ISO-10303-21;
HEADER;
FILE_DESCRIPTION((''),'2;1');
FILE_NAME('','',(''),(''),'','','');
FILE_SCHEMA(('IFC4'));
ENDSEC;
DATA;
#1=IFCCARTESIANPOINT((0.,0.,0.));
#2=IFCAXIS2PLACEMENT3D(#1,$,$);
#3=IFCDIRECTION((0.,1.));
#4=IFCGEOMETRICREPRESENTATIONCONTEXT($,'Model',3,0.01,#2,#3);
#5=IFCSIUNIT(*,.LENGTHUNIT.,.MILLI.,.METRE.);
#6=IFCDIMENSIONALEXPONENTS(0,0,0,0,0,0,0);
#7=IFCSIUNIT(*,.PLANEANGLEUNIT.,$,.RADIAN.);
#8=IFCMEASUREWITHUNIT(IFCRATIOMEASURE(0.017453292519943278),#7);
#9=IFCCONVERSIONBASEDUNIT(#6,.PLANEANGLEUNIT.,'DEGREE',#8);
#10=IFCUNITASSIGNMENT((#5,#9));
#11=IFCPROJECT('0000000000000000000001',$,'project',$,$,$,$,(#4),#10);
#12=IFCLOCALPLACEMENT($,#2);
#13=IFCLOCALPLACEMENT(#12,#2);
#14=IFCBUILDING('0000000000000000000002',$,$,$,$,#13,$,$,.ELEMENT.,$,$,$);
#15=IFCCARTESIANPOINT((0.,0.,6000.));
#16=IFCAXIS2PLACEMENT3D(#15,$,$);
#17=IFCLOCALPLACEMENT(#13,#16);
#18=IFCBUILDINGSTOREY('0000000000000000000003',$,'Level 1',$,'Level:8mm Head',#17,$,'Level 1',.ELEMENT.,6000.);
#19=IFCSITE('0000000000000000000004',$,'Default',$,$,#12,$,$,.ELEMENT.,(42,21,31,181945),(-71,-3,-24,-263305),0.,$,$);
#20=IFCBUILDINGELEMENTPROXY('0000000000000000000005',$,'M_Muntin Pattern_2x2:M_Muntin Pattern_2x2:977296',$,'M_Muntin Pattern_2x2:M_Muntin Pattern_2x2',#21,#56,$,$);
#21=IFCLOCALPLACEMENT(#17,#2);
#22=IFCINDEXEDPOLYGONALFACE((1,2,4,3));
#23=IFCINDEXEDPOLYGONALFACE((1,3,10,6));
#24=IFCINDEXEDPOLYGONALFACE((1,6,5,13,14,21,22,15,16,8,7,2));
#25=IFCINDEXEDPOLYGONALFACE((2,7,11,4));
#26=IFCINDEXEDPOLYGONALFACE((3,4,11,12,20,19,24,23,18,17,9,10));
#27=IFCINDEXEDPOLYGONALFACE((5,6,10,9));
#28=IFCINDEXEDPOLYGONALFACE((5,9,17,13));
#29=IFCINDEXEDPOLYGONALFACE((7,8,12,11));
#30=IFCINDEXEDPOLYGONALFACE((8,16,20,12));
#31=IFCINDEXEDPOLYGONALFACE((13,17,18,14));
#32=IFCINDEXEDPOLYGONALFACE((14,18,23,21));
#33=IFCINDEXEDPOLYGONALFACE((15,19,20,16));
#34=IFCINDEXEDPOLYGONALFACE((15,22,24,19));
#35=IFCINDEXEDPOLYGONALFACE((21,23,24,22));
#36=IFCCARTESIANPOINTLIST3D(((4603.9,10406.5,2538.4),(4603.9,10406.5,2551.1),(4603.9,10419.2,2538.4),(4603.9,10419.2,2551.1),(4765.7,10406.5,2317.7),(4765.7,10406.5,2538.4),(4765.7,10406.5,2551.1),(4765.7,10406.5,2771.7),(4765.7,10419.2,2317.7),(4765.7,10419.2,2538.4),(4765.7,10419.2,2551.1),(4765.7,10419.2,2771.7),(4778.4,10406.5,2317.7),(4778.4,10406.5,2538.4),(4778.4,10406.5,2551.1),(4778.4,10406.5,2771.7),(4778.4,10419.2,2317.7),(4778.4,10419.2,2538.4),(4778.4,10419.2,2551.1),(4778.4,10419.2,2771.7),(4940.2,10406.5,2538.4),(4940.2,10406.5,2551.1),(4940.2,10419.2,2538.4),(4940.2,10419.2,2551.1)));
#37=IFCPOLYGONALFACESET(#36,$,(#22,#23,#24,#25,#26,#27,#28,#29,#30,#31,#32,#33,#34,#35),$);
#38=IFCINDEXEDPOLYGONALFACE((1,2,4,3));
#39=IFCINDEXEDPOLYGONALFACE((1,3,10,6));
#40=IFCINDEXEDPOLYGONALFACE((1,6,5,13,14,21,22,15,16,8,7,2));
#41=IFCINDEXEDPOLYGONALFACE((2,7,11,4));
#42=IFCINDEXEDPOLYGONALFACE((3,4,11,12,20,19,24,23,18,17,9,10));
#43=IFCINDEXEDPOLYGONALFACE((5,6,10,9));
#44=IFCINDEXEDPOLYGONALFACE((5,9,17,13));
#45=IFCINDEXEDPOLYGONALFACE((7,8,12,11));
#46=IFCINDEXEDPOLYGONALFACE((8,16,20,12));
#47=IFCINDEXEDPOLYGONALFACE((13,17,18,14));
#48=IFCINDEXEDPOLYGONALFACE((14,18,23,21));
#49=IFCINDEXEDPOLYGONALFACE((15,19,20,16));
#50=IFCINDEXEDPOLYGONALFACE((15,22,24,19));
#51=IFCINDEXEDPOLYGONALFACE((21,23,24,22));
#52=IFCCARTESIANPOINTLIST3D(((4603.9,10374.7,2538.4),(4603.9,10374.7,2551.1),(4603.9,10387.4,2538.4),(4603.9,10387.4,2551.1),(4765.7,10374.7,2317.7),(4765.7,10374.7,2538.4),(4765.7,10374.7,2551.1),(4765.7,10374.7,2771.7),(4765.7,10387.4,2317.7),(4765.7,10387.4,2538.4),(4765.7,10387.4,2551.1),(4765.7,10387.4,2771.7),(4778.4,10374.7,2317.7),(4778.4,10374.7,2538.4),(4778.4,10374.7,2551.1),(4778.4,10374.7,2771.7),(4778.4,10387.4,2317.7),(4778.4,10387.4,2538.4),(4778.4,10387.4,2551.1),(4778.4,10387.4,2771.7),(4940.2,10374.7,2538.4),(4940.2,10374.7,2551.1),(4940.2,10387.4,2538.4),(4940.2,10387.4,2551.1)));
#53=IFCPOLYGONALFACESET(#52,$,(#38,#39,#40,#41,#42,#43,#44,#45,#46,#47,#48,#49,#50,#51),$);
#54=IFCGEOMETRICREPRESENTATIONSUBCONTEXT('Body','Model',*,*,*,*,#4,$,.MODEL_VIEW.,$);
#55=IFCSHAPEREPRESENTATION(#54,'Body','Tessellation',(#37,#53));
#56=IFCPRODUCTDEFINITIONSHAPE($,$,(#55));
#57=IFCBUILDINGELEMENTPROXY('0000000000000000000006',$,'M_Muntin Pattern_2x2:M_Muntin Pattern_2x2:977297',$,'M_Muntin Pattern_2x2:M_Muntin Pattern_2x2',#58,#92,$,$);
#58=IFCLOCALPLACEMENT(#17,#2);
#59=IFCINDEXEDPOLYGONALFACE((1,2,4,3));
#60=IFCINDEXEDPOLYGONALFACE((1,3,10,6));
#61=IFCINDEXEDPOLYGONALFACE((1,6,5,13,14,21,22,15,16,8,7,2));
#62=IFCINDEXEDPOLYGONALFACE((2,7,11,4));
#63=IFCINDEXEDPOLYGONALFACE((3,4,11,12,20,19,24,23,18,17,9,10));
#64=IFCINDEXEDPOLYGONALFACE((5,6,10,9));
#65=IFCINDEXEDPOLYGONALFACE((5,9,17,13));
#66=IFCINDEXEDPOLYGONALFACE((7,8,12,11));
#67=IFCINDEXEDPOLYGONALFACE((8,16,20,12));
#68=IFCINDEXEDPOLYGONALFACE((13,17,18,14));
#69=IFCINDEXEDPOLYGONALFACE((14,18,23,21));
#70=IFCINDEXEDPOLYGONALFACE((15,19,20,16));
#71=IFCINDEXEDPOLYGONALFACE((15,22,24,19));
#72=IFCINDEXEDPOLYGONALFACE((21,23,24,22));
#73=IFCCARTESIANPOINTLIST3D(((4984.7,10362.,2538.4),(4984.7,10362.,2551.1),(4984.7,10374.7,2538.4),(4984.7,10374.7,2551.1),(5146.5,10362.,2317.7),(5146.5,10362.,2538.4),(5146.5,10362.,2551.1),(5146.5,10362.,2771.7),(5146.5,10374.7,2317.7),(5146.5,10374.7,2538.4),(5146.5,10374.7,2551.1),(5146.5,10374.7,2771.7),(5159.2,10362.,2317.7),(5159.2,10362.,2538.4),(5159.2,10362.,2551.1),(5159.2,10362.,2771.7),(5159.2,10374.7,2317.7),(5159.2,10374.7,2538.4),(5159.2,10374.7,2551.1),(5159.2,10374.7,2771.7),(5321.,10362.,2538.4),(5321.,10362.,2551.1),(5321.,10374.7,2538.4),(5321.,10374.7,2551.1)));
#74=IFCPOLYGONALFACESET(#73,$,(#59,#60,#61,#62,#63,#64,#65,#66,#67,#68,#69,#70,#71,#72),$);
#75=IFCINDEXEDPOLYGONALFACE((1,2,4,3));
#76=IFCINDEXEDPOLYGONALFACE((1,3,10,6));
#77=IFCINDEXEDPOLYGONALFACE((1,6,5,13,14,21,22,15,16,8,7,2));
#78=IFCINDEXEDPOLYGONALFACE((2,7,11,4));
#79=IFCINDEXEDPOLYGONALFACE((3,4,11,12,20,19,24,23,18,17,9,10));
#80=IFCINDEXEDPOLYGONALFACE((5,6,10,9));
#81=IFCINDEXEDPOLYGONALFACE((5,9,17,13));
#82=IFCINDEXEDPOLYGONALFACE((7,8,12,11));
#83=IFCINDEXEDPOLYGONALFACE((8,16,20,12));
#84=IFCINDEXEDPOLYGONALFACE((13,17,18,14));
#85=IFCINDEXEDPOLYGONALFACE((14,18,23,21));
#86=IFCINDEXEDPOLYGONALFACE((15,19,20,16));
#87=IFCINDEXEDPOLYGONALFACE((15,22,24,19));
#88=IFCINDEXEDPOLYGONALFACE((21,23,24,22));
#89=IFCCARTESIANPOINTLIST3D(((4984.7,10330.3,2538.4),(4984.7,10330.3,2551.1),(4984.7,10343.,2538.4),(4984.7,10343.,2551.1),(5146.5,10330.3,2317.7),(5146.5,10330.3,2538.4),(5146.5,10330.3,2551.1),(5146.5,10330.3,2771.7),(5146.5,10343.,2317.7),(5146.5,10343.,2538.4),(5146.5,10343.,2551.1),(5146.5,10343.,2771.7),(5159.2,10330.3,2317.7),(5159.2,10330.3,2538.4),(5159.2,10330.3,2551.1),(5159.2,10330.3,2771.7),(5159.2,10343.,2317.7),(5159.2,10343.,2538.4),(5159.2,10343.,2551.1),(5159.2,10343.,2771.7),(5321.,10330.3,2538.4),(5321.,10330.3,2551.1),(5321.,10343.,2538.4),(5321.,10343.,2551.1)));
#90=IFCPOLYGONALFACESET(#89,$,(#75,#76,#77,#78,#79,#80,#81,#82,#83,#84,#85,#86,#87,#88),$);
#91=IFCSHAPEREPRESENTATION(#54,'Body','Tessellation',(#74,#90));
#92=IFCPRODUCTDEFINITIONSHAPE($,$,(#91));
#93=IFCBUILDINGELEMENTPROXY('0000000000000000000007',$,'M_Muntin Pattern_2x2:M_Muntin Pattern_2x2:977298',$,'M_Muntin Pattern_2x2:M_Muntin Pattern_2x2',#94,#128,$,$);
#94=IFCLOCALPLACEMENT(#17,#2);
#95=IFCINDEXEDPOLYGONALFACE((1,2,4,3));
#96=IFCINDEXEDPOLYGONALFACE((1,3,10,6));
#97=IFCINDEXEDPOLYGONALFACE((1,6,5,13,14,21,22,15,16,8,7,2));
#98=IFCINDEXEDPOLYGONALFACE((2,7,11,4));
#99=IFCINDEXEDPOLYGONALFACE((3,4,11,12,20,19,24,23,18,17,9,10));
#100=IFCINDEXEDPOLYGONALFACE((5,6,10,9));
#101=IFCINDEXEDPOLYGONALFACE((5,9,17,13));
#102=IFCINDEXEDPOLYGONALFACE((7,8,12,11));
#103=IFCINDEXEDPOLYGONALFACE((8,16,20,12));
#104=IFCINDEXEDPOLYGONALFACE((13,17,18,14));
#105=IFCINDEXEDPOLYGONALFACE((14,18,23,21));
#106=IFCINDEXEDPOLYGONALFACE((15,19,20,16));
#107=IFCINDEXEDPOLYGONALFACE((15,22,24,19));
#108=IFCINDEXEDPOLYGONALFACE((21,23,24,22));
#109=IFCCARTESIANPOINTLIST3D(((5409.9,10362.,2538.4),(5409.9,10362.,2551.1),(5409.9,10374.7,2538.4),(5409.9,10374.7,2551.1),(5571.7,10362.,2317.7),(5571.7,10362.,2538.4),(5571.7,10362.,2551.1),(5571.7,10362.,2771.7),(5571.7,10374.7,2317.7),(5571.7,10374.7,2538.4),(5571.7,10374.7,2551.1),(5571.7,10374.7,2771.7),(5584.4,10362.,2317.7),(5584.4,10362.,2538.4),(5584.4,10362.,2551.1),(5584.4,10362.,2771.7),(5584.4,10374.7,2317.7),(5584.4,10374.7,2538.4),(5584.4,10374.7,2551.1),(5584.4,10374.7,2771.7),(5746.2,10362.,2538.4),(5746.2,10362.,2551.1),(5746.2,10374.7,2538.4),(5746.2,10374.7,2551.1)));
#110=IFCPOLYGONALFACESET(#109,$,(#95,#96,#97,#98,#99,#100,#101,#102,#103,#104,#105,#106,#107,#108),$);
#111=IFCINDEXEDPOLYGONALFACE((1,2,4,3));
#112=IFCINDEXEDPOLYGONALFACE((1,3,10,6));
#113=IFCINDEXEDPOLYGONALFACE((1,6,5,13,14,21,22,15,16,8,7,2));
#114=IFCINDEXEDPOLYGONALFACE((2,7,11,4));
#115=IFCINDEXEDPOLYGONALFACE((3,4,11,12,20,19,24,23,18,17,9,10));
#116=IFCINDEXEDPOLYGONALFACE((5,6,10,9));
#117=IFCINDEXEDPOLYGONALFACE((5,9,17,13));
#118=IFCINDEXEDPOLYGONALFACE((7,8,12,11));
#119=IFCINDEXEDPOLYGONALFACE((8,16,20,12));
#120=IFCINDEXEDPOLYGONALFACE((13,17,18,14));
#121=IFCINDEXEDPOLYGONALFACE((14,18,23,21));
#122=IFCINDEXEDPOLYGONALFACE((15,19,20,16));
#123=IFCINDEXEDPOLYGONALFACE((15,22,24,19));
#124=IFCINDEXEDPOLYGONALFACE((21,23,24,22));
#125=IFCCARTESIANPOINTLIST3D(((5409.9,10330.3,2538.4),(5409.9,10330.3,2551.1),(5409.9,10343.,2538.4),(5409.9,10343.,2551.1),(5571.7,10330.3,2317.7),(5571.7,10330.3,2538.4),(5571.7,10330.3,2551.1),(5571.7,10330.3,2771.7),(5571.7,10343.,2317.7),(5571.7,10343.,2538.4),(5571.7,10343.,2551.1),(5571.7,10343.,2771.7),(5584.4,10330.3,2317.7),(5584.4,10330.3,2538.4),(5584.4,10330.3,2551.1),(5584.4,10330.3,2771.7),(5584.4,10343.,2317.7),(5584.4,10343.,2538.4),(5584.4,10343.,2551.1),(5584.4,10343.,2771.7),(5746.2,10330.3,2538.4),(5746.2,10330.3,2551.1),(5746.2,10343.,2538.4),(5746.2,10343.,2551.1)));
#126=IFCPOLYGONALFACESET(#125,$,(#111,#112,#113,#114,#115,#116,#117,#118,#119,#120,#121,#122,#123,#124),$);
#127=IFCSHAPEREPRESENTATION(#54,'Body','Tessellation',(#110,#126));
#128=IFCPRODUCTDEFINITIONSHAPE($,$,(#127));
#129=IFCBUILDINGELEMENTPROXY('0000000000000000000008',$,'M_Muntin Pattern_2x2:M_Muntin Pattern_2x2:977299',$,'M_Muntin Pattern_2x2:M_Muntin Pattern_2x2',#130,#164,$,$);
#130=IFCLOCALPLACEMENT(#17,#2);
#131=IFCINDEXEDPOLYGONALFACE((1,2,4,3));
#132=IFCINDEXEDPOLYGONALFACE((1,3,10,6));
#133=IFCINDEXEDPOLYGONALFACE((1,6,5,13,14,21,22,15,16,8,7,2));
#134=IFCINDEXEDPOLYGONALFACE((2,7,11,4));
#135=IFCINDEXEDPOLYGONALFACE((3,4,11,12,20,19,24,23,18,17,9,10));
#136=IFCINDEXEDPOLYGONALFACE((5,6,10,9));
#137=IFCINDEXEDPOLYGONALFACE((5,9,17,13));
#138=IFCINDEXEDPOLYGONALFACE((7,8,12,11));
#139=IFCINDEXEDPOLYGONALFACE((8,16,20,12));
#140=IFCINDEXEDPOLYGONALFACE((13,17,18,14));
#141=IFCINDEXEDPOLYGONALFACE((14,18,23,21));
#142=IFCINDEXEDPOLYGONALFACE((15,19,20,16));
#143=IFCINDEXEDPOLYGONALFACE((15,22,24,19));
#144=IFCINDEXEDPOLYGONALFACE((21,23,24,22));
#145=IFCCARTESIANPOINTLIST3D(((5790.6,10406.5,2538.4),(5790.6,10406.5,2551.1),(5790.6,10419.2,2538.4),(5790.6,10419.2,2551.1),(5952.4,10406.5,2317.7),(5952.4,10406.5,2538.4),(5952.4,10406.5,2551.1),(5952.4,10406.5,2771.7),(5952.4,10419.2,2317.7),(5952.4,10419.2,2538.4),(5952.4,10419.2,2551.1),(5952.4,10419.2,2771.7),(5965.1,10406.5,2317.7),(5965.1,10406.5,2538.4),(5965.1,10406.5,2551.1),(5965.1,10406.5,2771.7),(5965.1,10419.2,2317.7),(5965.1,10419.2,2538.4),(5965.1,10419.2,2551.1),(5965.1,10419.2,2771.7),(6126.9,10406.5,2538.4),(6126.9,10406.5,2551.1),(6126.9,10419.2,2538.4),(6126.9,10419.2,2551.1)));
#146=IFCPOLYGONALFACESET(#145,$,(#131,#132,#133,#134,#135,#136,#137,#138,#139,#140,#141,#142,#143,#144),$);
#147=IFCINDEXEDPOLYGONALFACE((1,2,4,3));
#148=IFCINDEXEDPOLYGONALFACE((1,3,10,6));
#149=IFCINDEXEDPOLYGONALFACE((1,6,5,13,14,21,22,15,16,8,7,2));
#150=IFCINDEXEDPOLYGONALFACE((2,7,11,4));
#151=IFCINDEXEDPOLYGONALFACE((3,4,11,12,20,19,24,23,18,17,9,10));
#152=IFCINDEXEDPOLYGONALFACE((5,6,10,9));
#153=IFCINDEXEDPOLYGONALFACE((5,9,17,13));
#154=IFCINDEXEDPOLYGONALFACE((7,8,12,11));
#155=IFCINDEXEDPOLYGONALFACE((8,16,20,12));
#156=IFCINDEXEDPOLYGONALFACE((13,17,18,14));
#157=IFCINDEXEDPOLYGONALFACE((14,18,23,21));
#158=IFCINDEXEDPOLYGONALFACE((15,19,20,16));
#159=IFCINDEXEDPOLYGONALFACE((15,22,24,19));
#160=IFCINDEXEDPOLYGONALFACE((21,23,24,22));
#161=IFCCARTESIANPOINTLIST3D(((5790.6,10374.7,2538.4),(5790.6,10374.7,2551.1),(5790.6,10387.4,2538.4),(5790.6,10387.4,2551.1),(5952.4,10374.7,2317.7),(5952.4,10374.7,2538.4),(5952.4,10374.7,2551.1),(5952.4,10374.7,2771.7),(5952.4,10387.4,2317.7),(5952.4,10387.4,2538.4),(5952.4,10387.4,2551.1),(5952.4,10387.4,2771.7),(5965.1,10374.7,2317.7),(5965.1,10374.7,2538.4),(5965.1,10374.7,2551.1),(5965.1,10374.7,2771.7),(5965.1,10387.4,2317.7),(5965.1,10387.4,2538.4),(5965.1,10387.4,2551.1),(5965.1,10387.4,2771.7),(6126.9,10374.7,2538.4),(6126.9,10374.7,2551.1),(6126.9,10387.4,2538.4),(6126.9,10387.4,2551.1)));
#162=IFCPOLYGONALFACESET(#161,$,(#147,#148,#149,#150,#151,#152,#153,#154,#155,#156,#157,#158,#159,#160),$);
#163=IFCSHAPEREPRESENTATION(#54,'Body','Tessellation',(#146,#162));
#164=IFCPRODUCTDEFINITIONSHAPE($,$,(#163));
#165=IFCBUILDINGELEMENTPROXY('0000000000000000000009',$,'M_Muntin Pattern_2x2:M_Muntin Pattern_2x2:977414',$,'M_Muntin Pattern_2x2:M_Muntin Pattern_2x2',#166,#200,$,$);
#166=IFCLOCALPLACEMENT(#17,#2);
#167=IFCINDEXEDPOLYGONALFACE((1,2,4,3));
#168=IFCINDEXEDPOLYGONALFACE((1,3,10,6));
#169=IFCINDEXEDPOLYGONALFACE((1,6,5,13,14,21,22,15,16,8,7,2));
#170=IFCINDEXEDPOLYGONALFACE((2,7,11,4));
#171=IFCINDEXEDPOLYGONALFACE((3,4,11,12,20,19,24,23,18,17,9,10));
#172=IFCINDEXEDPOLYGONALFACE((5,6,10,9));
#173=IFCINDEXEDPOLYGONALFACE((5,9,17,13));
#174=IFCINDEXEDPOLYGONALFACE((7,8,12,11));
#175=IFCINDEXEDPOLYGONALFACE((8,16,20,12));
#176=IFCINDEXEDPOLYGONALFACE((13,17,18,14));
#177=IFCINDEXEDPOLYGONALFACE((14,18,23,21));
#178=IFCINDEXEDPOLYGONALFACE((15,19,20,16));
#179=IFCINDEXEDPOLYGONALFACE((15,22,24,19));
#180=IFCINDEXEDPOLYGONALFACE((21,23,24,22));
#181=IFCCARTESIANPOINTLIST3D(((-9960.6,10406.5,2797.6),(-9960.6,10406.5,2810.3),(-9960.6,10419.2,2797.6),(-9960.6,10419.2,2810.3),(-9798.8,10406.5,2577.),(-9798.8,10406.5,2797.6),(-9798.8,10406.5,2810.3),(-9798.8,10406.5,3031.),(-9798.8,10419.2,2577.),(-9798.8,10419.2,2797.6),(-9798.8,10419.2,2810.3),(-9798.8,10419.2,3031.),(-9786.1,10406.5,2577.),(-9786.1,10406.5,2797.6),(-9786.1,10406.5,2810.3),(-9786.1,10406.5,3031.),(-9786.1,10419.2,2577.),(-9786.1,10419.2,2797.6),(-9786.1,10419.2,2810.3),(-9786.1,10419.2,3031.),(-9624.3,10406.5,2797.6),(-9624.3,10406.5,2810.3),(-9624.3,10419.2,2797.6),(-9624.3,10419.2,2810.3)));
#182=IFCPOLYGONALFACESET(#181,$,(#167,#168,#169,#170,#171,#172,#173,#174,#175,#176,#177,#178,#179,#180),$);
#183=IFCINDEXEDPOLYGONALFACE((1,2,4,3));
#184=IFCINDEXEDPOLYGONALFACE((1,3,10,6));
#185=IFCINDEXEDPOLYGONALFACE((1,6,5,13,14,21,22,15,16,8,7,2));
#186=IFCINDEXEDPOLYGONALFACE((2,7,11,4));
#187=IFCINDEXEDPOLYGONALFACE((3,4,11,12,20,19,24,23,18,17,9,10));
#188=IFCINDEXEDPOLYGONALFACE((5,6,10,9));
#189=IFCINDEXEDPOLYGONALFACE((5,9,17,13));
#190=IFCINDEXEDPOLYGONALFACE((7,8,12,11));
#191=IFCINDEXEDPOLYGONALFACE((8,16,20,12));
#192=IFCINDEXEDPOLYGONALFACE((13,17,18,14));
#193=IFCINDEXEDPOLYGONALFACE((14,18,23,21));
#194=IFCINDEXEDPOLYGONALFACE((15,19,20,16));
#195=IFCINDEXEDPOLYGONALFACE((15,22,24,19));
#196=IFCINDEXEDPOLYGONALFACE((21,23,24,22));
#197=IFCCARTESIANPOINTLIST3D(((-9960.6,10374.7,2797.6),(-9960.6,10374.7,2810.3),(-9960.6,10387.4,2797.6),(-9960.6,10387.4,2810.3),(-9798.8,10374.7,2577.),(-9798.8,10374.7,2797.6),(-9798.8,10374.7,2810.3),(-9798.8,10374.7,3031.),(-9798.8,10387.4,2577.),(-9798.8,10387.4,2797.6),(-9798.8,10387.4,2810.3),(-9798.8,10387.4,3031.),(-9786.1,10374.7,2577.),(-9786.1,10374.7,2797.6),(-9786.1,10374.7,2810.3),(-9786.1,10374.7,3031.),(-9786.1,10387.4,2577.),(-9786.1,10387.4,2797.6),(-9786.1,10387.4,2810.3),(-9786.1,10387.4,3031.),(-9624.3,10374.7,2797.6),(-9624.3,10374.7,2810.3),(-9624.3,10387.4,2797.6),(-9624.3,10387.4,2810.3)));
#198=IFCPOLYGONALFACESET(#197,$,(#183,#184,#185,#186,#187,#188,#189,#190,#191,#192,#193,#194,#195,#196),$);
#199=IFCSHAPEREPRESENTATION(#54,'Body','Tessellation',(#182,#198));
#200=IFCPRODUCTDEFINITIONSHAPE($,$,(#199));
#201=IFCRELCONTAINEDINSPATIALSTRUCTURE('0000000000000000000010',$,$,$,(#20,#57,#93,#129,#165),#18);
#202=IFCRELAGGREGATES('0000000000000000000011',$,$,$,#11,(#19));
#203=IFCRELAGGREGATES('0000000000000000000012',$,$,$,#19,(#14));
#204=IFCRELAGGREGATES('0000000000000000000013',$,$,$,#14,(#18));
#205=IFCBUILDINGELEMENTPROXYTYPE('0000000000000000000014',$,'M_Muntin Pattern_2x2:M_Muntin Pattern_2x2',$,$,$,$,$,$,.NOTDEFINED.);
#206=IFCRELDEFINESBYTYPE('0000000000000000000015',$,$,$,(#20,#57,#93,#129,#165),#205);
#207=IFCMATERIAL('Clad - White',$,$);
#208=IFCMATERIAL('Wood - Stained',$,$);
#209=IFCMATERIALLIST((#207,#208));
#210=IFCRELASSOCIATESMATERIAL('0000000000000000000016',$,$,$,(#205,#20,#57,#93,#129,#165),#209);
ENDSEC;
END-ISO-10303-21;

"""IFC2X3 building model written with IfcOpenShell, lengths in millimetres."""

from ifc_helpers import new_model, entity, si_unit, converted_unit, direction, frame, origin, place, context, subcontext, project, spatial, polyline, outline, extrude, source, transform, mapped, material, material_list, type_object, type_shapes, element, save


model = new_model("IFC2X3")

# Units and contexts
model_context = context("Model", 3, precision=0.01, world=origin(), true_north=direction((0.0, 1.0)))
body_context = subcontext(model_context, "Body", "Model", "MODEL_VIEW")
ifc_project = project(units=[si_unit("LENGTHUNIT", "METRE", prefix="MILLI"), converted_unit("PLANEANGLEUNIT", "DEGREE", entity("IfcRatioMeasure", 0.017453292519943278), si_unit("PLANEANGLEUNIT", "RADIAN"), dimensions=[0, 0, 0, 0, 0, 0, 0])], contexts=[model_context])

# Site, building, storey
site_placement = place(None, origin())
site = spatial("IfcSite", under=ifc_project, at=site_placement, Name="Default", CompositionType="ELEMENT", RefLatitude=(42, 21, 31, 181945), RefLongitude=(-71, -3, -24, -263305), RefElevation=0.0)
building_placement = place(site_placement, origin())
building = spatial("IfcBuilding", under=site, at=building_placement, CompositionType="ELEMENT")
storey_placement = place(building_placement, frame((0.0, 0.0, 6000.0)))
storey = spatial("IfcBuildingStorey", under=building, at=storey_placement, Name="Level 1", ObjectType="Level:8mm Head", LongName="Level 1", CompositionType="ELEMENT", Elevation=6000.0)

# Building element proxies
ifc_material_1 = material(Name="Clad - White")
ifc_material_2 = material(Name="Wood - Stained")
ifc_material_list_1 = material_list([ifc_material_1, ifc_material_2])
building_element_proxy_type_1 = type_object("IfcBuildingElementProxyType", Name="M_Muntin Pattern_2x2:M_Muntin Pattern_2x2", PredefinedType="NOTDEFINED", material=ifc_material_list_1)
shared_shape_1 = source(origin(), body_context, "Body", "SweptSolid", [
    extrude(outline(polyline([(6.4, -6.4), (227.0, -6.4), (227.0, 6.3), (6.4, 6.3), (6.4, 168.2), (-6.3, 168.2), (-6.3, 6.3), (-227.0, 6.3), (-227.0, -6.4), (-6.3, -6.4), (-6.3, -168.1), (6.4, -168.1), (6.4, -6.4)])), frame((0.0, 9.5, 227.0), z_axis=(0.0, 1.0, 0.0), x_axis=(0.0, 0.0, 1.0)), (0.0, 0.0, 1.0), 12.7),
    extrude(outline(polyline([(6.4, -6.4), (227.0, -6.4), (227.0, 6.3), (6.4, 6.3), (6.4, 168.2), (-6.3, 168.2), (-6.3, 6.3), (-227.0, 6.3), (-227.0, -6.4), (-6.3, -6.4), (-6.3, -168.1), (6.4, -168.1), (6.4, -6.4)])), frame((0.0, -22.2, 227.0), z_axis=(0.0, 1.0, 0.0), x_axis=(0.0, 0.0, 1.0)), (0.0, 0.0, 1.0), 12.7),
])
type_shapes(building_element_proxy_type_1, [shared_shape_1])
for number, where, name in (
    (1, (4772.1, 10396.9, 2317.7), "M_Muntin Pattern_2x2:M_Muntin Pattern_2x2:977296"),
    (2, (5152.8, 10352.5, 2317.7), "M_Muntin Pattern_2x2:M_Muntin Pattern_2x2:977297"),
    (3, (5578.0, 10352.5, 2317.7), "M_Muntin Pattern_2x2:M_Muntin Pattern_2x2:977298"),
    (4, (5958.8, 10396.9, 2317.7), "M_Muntin Pattern_2x2:M_Muntin Pattern_2x2:977299"),
    (5, (-9792.4, 10396.9, 2577.0), "M_Muntin Pattern_2x2:M_Muntin Pattern_2x2:977414"),
):
    element("IfcBuildingElementProxy", number, at=place(storey_placement, frame(where)), inside=storey, type_object=building_element_proxy_type_1, material=ifc_material_list_1, Name=name, ObjectType="M_Muntin Pattern_2x2:M_Muntin Pattern_2x2", context=body_context, shape_type="MappedRepresentation", body=[
        mapped(shared_shape_1, transform((0.0, 0.0, 0.0), scale=1.0)),
    ])

save(model, "model.ifc")
